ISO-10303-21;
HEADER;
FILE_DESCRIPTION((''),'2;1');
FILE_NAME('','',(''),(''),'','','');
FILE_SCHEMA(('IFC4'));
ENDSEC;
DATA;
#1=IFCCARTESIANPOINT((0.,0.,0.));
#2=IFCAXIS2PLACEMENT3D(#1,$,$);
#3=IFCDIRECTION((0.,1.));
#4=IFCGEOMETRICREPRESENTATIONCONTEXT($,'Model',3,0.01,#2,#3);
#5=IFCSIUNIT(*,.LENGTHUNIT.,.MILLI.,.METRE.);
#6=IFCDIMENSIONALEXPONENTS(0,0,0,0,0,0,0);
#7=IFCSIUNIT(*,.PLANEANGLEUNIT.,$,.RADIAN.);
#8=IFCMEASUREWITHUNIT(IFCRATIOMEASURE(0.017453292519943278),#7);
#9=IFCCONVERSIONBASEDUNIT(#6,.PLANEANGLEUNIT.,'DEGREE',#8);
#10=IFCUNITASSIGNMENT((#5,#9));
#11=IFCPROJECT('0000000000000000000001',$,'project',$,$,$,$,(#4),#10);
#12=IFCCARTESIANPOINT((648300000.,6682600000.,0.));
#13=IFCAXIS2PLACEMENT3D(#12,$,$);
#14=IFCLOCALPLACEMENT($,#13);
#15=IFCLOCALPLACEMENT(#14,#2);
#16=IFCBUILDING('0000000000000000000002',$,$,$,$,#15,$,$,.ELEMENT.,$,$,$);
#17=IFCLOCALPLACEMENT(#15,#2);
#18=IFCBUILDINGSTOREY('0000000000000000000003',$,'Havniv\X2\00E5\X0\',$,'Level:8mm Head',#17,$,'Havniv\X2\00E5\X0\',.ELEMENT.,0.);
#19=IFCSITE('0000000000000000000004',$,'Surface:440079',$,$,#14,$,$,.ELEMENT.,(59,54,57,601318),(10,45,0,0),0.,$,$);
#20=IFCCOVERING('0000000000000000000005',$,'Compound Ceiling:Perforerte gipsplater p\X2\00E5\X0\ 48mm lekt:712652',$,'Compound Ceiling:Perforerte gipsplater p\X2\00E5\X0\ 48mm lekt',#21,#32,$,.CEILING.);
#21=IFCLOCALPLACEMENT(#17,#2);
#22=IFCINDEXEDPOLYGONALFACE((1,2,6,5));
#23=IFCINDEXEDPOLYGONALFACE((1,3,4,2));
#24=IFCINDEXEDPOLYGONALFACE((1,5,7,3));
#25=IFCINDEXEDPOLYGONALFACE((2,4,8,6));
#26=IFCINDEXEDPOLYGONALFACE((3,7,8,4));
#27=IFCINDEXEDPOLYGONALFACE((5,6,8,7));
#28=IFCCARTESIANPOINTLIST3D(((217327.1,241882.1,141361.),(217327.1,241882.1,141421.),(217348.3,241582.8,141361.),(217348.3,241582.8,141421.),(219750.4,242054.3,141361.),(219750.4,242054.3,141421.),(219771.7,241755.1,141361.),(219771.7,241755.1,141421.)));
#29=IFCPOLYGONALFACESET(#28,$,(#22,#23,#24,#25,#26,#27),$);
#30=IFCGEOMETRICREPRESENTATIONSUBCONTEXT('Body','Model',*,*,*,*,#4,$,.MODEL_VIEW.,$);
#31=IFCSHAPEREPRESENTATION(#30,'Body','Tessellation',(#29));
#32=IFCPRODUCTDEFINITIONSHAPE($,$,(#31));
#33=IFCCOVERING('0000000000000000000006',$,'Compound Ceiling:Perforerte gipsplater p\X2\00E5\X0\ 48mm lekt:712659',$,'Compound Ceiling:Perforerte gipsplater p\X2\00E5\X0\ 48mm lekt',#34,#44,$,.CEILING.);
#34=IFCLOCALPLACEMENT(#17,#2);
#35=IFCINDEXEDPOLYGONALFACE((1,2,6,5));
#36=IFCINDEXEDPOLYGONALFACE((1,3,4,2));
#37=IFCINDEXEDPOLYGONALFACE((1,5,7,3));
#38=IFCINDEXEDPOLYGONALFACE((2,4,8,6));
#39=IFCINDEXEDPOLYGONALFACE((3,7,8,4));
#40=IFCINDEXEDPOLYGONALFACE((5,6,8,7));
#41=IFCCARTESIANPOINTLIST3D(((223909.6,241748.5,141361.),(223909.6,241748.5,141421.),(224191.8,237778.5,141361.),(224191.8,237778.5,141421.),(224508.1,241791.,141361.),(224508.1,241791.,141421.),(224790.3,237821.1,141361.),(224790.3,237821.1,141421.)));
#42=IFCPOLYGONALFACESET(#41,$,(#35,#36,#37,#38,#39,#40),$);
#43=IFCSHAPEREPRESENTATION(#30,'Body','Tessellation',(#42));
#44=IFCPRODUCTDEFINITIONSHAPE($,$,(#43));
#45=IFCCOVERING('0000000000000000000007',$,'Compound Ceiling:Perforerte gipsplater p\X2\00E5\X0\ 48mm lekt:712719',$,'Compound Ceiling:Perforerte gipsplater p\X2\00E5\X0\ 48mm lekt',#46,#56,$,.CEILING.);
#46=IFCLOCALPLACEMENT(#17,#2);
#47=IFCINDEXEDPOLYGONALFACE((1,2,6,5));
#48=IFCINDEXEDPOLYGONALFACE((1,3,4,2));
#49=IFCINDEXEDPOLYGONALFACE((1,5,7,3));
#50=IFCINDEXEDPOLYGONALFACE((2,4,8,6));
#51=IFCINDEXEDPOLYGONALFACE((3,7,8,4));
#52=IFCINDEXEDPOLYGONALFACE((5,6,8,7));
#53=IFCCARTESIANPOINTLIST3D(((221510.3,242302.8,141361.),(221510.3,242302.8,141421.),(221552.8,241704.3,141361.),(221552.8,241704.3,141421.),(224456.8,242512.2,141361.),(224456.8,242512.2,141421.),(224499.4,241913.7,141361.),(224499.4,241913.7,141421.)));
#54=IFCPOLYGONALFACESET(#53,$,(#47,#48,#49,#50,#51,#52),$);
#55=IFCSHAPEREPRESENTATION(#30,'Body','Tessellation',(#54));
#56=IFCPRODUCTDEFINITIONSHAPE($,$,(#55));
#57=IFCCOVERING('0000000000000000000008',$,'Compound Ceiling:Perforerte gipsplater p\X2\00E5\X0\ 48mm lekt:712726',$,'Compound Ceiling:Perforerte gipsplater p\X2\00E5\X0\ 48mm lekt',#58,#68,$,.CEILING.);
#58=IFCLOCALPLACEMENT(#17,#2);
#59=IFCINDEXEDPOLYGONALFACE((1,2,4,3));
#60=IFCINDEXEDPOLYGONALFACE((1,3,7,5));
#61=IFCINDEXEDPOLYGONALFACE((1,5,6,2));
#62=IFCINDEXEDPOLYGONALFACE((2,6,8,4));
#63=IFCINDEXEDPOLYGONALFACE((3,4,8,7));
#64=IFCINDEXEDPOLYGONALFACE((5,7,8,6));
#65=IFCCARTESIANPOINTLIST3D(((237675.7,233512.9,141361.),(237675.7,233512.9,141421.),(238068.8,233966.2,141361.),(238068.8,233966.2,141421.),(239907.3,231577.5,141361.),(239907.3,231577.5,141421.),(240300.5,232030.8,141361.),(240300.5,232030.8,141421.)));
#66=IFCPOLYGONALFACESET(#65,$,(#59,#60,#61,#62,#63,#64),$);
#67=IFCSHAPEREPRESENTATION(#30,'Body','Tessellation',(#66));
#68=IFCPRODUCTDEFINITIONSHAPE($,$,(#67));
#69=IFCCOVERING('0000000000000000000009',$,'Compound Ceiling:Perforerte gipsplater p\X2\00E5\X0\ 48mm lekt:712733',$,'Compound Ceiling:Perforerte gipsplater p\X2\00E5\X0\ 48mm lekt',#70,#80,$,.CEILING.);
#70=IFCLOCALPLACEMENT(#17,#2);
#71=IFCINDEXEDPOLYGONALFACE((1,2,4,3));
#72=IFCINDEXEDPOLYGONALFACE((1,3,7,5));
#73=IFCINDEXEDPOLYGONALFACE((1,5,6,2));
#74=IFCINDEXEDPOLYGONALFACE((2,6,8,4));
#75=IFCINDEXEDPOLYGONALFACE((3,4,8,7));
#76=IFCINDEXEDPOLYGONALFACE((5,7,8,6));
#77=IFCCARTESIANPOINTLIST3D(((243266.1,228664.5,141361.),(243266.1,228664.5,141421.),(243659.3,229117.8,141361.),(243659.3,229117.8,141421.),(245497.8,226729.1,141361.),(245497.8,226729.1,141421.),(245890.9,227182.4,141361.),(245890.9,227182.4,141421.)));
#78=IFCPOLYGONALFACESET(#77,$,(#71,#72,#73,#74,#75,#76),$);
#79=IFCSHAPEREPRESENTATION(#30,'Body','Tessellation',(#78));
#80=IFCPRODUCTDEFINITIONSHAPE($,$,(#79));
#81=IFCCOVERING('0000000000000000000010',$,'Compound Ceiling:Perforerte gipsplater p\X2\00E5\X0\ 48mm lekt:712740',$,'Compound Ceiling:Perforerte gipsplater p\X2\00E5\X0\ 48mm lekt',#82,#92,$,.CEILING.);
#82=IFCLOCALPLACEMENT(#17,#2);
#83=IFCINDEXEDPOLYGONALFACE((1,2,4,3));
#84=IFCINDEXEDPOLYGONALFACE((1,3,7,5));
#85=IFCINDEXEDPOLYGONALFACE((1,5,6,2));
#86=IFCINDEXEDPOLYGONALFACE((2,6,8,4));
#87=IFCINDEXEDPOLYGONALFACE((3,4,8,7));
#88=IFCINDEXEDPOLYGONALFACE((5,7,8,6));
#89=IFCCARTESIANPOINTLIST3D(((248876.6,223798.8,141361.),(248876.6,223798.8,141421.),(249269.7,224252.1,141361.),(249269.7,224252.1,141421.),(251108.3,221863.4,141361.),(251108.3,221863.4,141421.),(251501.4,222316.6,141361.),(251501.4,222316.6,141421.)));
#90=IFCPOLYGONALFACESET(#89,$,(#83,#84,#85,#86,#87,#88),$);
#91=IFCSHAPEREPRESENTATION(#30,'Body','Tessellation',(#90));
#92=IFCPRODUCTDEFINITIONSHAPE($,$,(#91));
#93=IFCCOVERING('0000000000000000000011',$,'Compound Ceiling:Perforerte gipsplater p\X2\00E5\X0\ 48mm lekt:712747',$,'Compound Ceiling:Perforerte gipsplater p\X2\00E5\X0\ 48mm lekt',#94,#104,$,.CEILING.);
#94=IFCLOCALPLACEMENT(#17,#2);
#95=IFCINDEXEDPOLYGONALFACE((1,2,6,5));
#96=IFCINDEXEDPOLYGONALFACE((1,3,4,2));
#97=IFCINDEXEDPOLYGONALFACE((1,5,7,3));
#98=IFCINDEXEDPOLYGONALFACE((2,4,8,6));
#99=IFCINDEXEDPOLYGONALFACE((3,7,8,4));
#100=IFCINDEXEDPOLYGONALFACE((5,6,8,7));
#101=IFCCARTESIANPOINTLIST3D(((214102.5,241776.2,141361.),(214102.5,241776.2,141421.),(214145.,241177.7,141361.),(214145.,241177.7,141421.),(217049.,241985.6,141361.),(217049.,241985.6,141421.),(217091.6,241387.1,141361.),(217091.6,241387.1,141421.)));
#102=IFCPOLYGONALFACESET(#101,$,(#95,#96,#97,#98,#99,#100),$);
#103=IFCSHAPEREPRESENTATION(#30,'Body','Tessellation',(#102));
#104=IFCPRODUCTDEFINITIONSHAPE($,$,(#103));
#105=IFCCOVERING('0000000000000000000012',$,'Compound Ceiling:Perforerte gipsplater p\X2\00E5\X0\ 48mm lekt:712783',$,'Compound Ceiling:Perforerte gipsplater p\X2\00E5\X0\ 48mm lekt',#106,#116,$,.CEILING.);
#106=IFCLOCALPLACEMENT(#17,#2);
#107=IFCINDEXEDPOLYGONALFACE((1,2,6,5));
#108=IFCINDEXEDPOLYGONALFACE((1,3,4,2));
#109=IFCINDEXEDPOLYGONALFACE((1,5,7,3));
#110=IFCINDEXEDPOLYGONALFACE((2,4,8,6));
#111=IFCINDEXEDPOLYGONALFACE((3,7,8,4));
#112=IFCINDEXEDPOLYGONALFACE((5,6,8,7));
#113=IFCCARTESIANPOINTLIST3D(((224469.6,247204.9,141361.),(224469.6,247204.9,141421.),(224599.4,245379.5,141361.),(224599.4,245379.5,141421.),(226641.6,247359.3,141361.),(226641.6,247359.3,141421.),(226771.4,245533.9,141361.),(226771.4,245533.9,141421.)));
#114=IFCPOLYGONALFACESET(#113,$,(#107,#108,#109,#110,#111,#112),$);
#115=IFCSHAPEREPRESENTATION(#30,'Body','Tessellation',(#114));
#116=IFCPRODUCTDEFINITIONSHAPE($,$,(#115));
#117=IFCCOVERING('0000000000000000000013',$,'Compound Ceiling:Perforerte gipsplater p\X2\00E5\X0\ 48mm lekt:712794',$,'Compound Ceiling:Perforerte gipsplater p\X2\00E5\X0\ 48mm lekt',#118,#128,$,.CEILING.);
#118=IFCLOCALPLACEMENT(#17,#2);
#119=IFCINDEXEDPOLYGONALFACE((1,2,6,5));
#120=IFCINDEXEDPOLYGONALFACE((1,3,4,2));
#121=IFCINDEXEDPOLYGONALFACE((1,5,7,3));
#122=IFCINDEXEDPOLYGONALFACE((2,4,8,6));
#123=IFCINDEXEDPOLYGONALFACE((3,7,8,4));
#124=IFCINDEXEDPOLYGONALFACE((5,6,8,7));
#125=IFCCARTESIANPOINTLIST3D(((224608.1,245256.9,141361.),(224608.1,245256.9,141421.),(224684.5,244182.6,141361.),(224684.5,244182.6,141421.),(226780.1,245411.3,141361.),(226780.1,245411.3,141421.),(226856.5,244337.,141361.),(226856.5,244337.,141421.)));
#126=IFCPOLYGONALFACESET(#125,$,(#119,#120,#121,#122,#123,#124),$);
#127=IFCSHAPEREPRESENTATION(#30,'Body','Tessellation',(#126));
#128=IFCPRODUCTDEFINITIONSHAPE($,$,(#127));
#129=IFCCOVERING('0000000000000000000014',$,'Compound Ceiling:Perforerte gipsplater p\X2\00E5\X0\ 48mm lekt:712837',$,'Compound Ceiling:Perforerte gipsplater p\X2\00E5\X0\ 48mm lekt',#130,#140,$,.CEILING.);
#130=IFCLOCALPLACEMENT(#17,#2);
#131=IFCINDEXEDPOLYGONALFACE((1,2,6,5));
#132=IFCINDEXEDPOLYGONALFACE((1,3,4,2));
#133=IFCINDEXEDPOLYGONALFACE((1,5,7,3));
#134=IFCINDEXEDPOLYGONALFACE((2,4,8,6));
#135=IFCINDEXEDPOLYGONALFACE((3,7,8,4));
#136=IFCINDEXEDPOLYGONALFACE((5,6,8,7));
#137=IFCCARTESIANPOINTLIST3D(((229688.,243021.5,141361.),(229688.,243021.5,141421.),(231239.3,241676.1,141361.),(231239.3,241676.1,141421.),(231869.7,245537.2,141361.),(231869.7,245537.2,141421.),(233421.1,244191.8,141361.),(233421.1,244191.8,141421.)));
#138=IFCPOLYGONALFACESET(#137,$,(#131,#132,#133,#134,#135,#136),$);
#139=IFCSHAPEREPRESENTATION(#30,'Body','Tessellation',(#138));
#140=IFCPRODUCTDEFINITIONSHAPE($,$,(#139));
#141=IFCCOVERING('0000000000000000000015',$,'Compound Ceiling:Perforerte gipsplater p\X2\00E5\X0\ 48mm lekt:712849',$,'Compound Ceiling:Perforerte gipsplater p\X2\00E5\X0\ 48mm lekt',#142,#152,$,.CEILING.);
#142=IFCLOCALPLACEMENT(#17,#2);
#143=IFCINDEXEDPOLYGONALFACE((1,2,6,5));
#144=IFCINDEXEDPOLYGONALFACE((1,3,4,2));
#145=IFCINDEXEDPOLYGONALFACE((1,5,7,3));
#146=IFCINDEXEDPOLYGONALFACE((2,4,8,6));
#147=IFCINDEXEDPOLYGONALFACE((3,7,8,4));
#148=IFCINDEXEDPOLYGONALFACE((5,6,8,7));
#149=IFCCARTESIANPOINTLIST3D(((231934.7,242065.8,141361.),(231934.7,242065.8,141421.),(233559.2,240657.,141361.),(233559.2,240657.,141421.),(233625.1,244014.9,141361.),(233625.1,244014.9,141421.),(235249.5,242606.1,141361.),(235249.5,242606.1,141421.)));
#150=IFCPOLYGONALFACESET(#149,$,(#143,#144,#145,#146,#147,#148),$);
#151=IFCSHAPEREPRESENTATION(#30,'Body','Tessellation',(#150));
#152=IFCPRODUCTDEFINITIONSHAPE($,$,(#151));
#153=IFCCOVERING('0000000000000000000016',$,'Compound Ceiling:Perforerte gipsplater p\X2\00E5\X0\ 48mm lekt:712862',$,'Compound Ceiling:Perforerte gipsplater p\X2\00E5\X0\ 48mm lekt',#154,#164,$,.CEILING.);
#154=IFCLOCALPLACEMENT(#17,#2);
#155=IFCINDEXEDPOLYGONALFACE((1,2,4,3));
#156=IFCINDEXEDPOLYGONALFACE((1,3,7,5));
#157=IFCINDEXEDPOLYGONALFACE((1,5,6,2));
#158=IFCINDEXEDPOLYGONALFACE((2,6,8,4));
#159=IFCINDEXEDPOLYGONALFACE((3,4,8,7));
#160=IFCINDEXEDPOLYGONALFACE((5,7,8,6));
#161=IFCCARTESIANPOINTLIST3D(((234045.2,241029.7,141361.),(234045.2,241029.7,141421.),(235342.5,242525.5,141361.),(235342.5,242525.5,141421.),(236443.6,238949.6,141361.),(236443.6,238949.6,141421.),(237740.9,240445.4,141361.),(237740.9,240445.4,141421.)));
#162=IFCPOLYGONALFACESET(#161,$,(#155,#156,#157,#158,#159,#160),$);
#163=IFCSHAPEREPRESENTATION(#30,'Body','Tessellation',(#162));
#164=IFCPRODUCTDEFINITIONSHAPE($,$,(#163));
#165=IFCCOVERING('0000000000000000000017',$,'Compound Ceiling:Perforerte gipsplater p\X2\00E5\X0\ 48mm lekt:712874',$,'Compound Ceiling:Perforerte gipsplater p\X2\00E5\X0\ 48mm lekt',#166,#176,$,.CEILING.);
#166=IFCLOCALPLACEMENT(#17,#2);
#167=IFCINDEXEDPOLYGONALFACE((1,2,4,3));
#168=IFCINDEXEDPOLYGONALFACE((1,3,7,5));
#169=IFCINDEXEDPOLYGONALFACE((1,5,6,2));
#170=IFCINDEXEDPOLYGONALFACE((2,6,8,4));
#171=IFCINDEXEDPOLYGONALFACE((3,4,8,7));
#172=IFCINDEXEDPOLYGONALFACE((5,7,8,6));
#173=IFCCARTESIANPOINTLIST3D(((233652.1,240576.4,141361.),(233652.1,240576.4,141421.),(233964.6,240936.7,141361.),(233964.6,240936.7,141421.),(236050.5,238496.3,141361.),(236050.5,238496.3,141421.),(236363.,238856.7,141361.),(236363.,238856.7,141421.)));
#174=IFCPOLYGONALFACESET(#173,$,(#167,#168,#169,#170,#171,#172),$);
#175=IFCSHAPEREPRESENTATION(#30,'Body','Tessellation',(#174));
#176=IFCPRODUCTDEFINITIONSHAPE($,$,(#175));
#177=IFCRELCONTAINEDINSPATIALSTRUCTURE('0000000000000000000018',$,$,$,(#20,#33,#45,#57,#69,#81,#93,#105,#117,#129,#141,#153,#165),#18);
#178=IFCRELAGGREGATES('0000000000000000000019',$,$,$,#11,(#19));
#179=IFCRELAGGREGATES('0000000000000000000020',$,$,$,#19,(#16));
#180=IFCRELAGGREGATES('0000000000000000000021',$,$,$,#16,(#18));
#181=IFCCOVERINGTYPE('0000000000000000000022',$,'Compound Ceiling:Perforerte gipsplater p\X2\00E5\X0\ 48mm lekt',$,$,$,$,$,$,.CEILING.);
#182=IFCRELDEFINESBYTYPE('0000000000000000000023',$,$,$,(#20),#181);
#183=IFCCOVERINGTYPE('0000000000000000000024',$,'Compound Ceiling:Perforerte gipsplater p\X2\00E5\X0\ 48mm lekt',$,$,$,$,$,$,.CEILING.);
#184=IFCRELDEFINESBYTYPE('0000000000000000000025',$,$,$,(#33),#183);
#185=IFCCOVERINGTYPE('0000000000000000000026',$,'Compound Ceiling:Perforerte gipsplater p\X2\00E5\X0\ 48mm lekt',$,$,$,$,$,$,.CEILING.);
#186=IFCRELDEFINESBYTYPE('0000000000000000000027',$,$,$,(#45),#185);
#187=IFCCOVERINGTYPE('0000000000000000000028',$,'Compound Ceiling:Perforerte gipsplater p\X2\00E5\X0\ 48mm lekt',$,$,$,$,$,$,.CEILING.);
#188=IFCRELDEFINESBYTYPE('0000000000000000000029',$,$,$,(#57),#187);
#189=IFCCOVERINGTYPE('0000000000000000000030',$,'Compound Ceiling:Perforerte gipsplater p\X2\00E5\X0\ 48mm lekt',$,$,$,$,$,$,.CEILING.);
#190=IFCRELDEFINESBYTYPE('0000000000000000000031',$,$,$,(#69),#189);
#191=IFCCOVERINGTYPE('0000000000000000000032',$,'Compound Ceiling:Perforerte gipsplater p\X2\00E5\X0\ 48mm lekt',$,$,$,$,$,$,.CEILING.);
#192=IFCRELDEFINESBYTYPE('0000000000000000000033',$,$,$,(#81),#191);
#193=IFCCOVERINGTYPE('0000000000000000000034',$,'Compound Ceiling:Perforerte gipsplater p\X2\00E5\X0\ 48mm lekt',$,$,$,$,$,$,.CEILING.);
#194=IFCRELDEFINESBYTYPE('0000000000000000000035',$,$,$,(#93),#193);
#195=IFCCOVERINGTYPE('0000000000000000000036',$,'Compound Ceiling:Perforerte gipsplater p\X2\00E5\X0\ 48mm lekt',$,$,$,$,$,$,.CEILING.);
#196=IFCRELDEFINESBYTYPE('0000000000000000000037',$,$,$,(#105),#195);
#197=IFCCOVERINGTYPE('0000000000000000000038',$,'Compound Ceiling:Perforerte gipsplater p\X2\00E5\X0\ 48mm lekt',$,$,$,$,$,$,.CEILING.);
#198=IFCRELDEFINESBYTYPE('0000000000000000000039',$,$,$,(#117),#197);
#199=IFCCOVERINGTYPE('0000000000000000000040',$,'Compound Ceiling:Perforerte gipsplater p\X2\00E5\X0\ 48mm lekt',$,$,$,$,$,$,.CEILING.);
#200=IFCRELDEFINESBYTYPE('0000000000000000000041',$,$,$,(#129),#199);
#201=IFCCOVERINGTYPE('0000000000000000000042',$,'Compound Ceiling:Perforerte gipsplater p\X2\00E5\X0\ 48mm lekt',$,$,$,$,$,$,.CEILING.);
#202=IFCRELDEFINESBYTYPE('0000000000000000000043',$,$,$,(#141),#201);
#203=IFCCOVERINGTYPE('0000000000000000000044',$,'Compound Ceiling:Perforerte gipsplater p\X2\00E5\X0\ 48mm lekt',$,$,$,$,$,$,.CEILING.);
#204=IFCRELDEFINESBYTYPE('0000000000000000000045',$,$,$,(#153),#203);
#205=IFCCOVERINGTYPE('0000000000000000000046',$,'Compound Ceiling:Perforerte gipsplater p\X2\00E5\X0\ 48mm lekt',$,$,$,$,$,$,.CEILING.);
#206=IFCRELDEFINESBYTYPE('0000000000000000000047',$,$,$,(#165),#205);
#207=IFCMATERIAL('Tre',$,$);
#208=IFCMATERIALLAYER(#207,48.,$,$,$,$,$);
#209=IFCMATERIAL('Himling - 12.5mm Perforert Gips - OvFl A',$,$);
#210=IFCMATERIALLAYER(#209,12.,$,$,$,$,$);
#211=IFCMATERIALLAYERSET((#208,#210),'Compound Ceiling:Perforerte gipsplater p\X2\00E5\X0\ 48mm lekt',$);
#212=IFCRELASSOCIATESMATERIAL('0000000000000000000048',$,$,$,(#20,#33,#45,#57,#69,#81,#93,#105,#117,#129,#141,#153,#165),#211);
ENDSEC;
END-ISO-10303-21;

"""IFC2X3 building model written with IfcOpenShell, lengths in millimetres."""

from ifc_helpers import new_model, entity, si_unit, converted_unit, direction, frame, frame_2d, origin, origin_2d_with_axis, place, context, subcontext, project, spatial, rectangle, extrude, material, layer, layer_set, layer_usage, type_object, element, save


model = new_model("IFC2X3")

# Units and contexts
model_context = context("Model", 3, precision=0.01, world=origin(), true_north=direction((0.0, 1.0)))
body_context = subcontext(model_context, "Body", "Model", "MODEL_VIEW")
ifc_project = project(units=[si_unit("LENGTHUNIT", "METRE", prefix="MILLI"), converted_unit("PLANEANGLEUNIT", "DEGREE", entity("IfcRatioMeasure", 0.017453292519943278), si_unit("PLANEANGLEUNIT", "RADIAN"), dimensions=[0, 0, 0, 0, 0, 0, 0])], contexts=[model_context])

# Site, building, storey
site_placement = place(None, frame((648300000.0, 6682600000.0, 0.0)))
site = spatial("IfcSite", under=ifc_project, at=site_placement, Name="Surface:440079", CompositionType="ELEMENT", RefLatitude=(59, 54, 57, 601318), RefLongitude=(10, 45, 0, 0), RefElevation=0.0)
building_placement = place(site_placement, origin())
building = spatial("IfcBuilding", under=site, at=building_placement, CompositionType="ELEMENT")
storey_placement = place(building_placement, origin())
storey = spatial("IfcBuildingStorey", under=building, at=storey_placement, Name="Havnivå", ObjectType="Level:8mm Head", LongName="Havnivå", CompositionType="ELEMENT", Elevation=0.0)

# Coverings
ifc_material_1 = material(Name="Tre")
ifc_layer_1 = layer(ifc_material_1, 48.0)
ifc_material_2 = material(Name="Himling - 12.5mm Perforert Gips - OvFl A")
ifc_layer_2 = layer(ifc_material_2, 12.0)
ifc_layer_set_1 = layer_set([ifc_layer_1, ifc_layer_2], Name="Compound Ceiling:Perforerte gipsplater på 48mm lekt")
ifc_layer_usage_1 = layer_usage(ifc_layer_set_1, "AXIS3", "POSITIVE", 0.0)
covering_type_1 = type_object("IfcCoveringType", Name="Compound Ceiling:Perforerte gipsplater på 48mm lekt", PredefinedType="CEILING")
covering_1_placement = place(storey_placement, origin())
element("IfcCovering", 1, at=covering_1_placement, inside=storey, type_object=covering_type_1, material=ifc_layer_usage_1, Name="Compound Ceiling:Perforerte gipsplater på 48mm lekt:712652", ObjectType="Compound Ceiling:Perforerte gipsplater på 48mm lekt", PredefinedType="CEILING", context=body_context, shape_type="SweptSolid", body=[
    extrude(rectangle(XDim=300.0, YDim=2429.5, at=frame_2d((0.0, 0.0), x_axis=(1.0, 0.0))), frame((218549.4, 241818.6, 141361.0), z_axis=(0.0, 0.0, 1.0), x_axis=(-0.070908, 0.997483, 0.0)), (0.0, 0.0, 1.0), 60.0),
])
ifc_layer_usage_2 = layer_usage(ifc_layer_set_1, "AXIS3", "POSITIVE", 0.0)
covering_type_2 = type_object("IfcCoveringType", Name="Compound Ceiling:Perforerte gipsplater på 48mm lekt", PredefinedType="CEILING")
covering_2_placement = place(storey_placement, origin())
element("IfcCovering", 2, at=covering_2_placement, inside=storey, type_object=covering_type_2, material=ifc_layer_usage_2, Name="Compound Ceiling:Perforerte gipsplater på 48mm lekt:712659", ObjectType="Compound Ceiling:Perforerte gipsplater på 48mm lekt", PredefinedType="CEILING", context=body_context, shape_type="SweptSolid", body=[
    extrude(rectangle(XDim=3980.0, YDim=600.0, at=origin_2d_with_axis()), frame((224350.0, 239784.8, 141361.0), z_axis=(0.0, 0.0, 1.0), x_axis=(0.070908, -0.997483, 0.0)), (0.0, 0.0, 1.0), 60.0),
])
ifc_layer_usage_3 = layer_usage(ifc_layer_set_1, "AXIS3", "POSITIVE", 0.0)
covering_type_3 = type_object("IfcCoveringType", Name="Compound Ceiling:Perforerte gipsplater på 48mm lekt", PredefinedType="CEILING")
covering_3_placement = place(storey_placement, origin())
element("IfcCovering", 3, at=covering_3_placement, inside=storey, type_object=covering_type_3, material=ifc_layer_usage_3, Name="Compound Ceiling:Perforerte gipsplater på 48mm lekt:712719", ObjectType="Compound Ceiling:Perforerte gipsplater på 48mm lekt", PredefinedType="CEILING", context=body_context, shape_type="SweptSolid", body=[
    extrude(rectangle(XDim=600.0, YDim=2954.0, at=frame_2d((0.0, 0.0), x_axis=(1.0, 0.0))), frame((223004.8, 242108.2, 141361.0), z_axis=(0.0, 0.0, 1.0), x_axis=(-0.070908, 0.997483, 0.0)), (0.0, 0.0, 1.0), 60.0),
])
ifc_layer_usage_4 = layer_usage(ifc_layer_set_1, "AXIS3", "POSITIVE", 0.0)
covering_type_4 = type_object("IfcCoveringType", Name="Compound Ceiling:Perforerte gipsplater på 48mm lekt", PredefinedType="CEILING")
covering_4_placement = place(storey_placement, origin())
element("IfcCovering", 4, at=covering_4_placement, inside=storey, type_object=covering_type_4, material=ifc_layer_usage_4, Name="Compound Ceiling:Perforerte gipsplater på 48mm lekt:712726", ObjectType="Compound Ceiling:Perforerte gipsplater på 48mm lekt", PredefinedType="CEILING", context=body_context, shape_type="SweptSolid", body=[
    extrude(rectangle(XDim=600.0, YDim=2954.0, at=origin_2d_with_axis()), frame((238988.1, 232771.8, 141361.0), z_axis=(0.0, 0.0, 1.0), x_axis=(0.655187, 0.755467, 0.0)), (0.0, 0.0, 1.0), 60.0),
])
ifc_layer_usage_5 = layer_usage(ifc_layer_set_1, "AXIS3", "POSITIVE", 0.0)
covering_type_5 = type_object("IfcCoveringType", Name="Compound Ceiling:Perforerte gipsplater på 48mm lekt", PredefinedType="CEILING")
covering_5_placement = place(storey_placement, origin())
element("IfcCovering", 5, at=covering_5_placement, inside=storey, type_object=covering_type_5, material=ifc_layer_usage_5, Name="Compound Ceiling:Perforerte gipsplater på 48mm lekt:712733", ObjectType="Compound Ceiling:Perforerte gipsplater på 48mm lekt", PredefinedType="CEILING", context=body_context, shape_type="SweptSolid", body=[
    extrude(rectangle(XDim=600.0, YDim=2954.0, at=frame_2d((0.0, 0.0), x_axis=(1.0, 0.0))), frame((244578.5, 227923.4, 141361.0), z_axis=(0.0, 0.0, 1.0), x_axis=(0.655187, 0.755467, 0.0)), (0.0, 0.0, 1.0), 60.0),
])
ifc_layer_usage_6 = layer_usage(ifc_layer_set_1, "AXIS3", "POSITIVE", 0.0)
covering_type_6 = type_object("IfcCoveringType", Name="Compound Ceiling:Perforerte gipsplater på 48mm lekt", PredefinedType="CEILING")
covering_6_placement = place(storey_placement, origin())
element("IfcCovering", 6, at=covering_6_placement, inside=storey, type_object=covering_type_6, material=ifc_layer_usage_6, Name="Compound Ceiling:Perforerte gipsplater på 48mm lekt:712740", ObjectType="Compound Ceiling:Perforerte gipsplater på 48mm lekt", PredefinedType="CEILING", context=body_context, shape_type="SweptSolid", body=[
    extrude(rectangle(XDim=600.0, YDim=2954.0, at=frame_2d((0.0, 0.0), x_axis=(1.0, 0.0))), frame((250189.0, 223057.7, 141361.0), z_axis=(0.0, 0.0, 1.0), x_axis=(0.655187, 0.755467, 0.0)), (0.0, 0.0, 1.0), 60.0),
])
ifc_layer_usage_7 = layer_usage(ifc_layer_set_1, "AXIS3", "POSITIVE", 0.0)
covering_type_7 = type_object("IfcCoveringType", Name="Compound Ceiling:Perforerte gipsplater på 48mm lekt", PredefinedType="CEILING")
covering_7_placement = place(storey_placement, origin())
element("IfcCovering", 7, at=covering_7_placement, inside=storey, type_object=covering_type_7, material=ifc_layer_usage_7, Name="Compound Ceiling:Perforerte gipsplater på 48mm lekt:712747", ObjectType="Compound Ceiling:Perforerte gipsplater på 48mm lekt", PredefinedType="CEILING", context=body_context, shape_type="SweptSolid", body=[
    extrude(rectangle(XDim=600.0, YDim=2954.0, at=frame_2d((0.0, 0.0), x_axis=(1.0, 0.0))), frame((215597.0, 241581.6, 141361.0), z_axis=(0.0, 0.0, 1.0), x_axis=(-0.070908, 0.997483, 0.0)), (0.0, 0.0, 1.0), 60.0),
])
ifc_layer_usage_8 = layer_usage(ifc_layer_set_1, "AXIS3", "POSITIVE", 0.0)
covering_type_8 = type_object("IfcCoveringType", Name="Compound Ceiling:Perforerte gipsplater på 48mm lekt", PredefinedType="CEILING")
covering_8_placement = place(storey_placement, origin())
element("IfcCovering", 8, at=covering_8_placement, inside=storey, type_object=covering_type_8, material=ifc_layer_usage_8, Name="Compound Ceiling:Perforerte gipsplater på 48mm lekt:712783", ObjectType="Compound Ceiling:Perforerte gipsplater på 48mm lekt", PredefinedType="CEILING", context=body_context, shape_type="SweptSolid", body=[
    extrude(rectangle(XDim=2177.5, YDim=1830.0, at=origin_2d_with_axis()), frame((225620.5, 246369.4, 141361.0), z_axis=(0.0, 0.0, 1.0), x_axis=(0.997483, 0.070908, 0.0)), (0.0, 0.0, 1.0), 60.0),
])
ifc_layer_usage_9 = layer_usage(ifc_layer_set_1, "AXIS3", "POSITIVE", 0.0)
covering_type_9 = type_object("IfcCoveringType", Name="Compound Ceiling:Perforerte gipsplater på 48mm lekt", PredefinedType="CEILING")
covering_9_placement = place(storey_placement, origin())
element("IfcCovering", 9, at=covering_9_placement, inside=storey, type_object=covering_type_9, material=ifc_layer_usage_9, Name="Compound Ceiling:Perforerte gipsplater på 48mm lekt:712794", ObjectType="Compound Ceiling:Perforerte gipsplater på 48mm lekt", PredefinedType="CEILING", context=body_context, shape_type="SweptSolid", body=[
    extrude(rectangle(XDim=1077.0, YDim=2177.5, at=frame_2d((0.0, 0.0), x_axis=(1.0, 0.0))), frame((225732.3, 244796.9, 141361.0), z_axis=(0.0, 0.0, 1.0), x_axis=(0.070908, -0.997483, 0.0)), (0.0, 0.0, 1.0), 60.0),
])
ifc_layer_usage_10 = layer_usage(ifc_layer_set_1, "AXIS3", "POSITIVE", 0.0)
covering_type_10 = type_object("IfcCoveringType", Name="Compound Ceiling:Perforerte gipsplater på 48mm lekt", PredefinedType="CEILING")
covering_10_placement = place(storey_placement, origin())
element("IfcCovering", 10, at=covering_10_placement, inside=storey, type_object=covering_type_10, material=ifc_layer_usage_10, Name="Compound Ceiling:Perforerte gipsplater på 48mm lekt:712837", ObjectType="Compound Ceiling:Perforerte gipsplater på 48mm lekt", PredefinedType="CEILING", context=body_context, shape_type="SweptSolid", body=[
    extrude(rectangle(XDim=2053.5, YDim=3330.0, at=frame_2d((0.0, 0.0), x_axis=(1.0, 0.0))), frame((231554.5, 243606.7, 141361.0), z_axis=(0.0, 0.0, 1.0), x_axis=(-0.755467, 0.655187, 0.0)), (0.0, 0.0, 1.0), 60.0),
])
ifc_layer_usage_11 = layer_usage(ifc_layer_set_1, "AXIS3", "POSITIVE", 0.0)
covering_type_11 = type_object("IfcCoveringType", Name="Compound Ceiling:Perforerte gipsplater på 48mm lekt", PredefinedType="CEILING")
covering_11_placement = place(storey_placement, origin())
element("IfcCovering", 11, at=covering_11_placement, inside=storey, type_object=covering_type_11, material=ifc_layer_usage_11, Name="Compound Ceiling:Perforerte gipsplater på 48mm lekt:712849", ObjectType="Compound Ceiling:Perforerte gipsplater på 48mm lekt", PredefinedType="CEILING", context=body_context, shape_type="SweptSolid", body=[
    extrude(rectangle(XDim=2580.0, YDim=2150.3, at=frame_2d((0.0, 0.0), x_axis=(1.0, 0.0))), frame((233592.1, 242335.9, 141361.0), z_axis=(0.0, 0.0, 1.0), x_axis=(-0.655187, -0.755467, 0.0)), (0.0, 0.0, 1.0), 60.0),
])
ifc_layer_usage_12 = layer_usage(ifc_layer_set_1, "AXIS3", "POSITIVE", 0.0)
covering_type_12 = type_object("IfcCoveringType", Name="Compound Ceiling:Perforerte gipsplater på 48mm lekt", PredefinedType="CEILING")
covering_12_placement = place(storey_placement, origin())
element("IfcCovering", 12, at=covering_12_placement, inside=storey, type_object=covering_type_12, material=ifc_layer_usage_12, Name="Compound Ceiling:Perforerte gipsplater på 48mm lekt:712862", ObjectType="Compound Ceiling:Perforerte gipsplater på 48mm lekt", PredefinedType="CEILING", context=body_context, shape_type="SweptSolid", body=[
    extrude(rectangle(XDim=3174.7, YDim=1980.0, at=frame_2d((0.0, 0.0), x_axis=(1.0, 0.0))), frame((235893.0, 240737.5, 141361.0), z_axis=(0.0, 0.0, 1.0), x_axis=(-0.755467, 0.655187, 0.0)), (0.0, 0.0, 1.0), 60.0),
])
ifc_layer_usage_13 = layer_usage(ifc_layer_set_1, "AXIS3", "POSITIVE", 0.0)
covering_type_13 = type_object("IfcCoveringType", Name="Compound Ceiling:Perforerte gipsplater på 48mm lekt", PredefinedType="CEILING")
covering_13_placement = place(storey_placement, origin())
element("IfcCovering", 13, at=covering_13_placement, inside=storey, type_object=covering_type_13, material=ifc_layer_usage_13, Name="Compound Ceiling:Perforerte gipsplater på 48mm lekt:712874", ObjectType="Compound Ceiling:Perforerte gipsplater på 48mm lekt", PredefinedType="CEILING", context=body_context, shape_type="SweptSolid", body=[
    extrude(rectangle(XDim=477.0, YDim=3174.7, at=frame_2d((0.0, 0.0), x_axis=(1.0, 0.0))), frame((235007.5, 239716.5, 141361.0), z_axis=(0.0, 0.0, 1.0), x_axis=(0.655187, 0.755467, 0.0)), (0.0, 0.0, 1.0), 60.0),
])

save(model, "model.ifc")
